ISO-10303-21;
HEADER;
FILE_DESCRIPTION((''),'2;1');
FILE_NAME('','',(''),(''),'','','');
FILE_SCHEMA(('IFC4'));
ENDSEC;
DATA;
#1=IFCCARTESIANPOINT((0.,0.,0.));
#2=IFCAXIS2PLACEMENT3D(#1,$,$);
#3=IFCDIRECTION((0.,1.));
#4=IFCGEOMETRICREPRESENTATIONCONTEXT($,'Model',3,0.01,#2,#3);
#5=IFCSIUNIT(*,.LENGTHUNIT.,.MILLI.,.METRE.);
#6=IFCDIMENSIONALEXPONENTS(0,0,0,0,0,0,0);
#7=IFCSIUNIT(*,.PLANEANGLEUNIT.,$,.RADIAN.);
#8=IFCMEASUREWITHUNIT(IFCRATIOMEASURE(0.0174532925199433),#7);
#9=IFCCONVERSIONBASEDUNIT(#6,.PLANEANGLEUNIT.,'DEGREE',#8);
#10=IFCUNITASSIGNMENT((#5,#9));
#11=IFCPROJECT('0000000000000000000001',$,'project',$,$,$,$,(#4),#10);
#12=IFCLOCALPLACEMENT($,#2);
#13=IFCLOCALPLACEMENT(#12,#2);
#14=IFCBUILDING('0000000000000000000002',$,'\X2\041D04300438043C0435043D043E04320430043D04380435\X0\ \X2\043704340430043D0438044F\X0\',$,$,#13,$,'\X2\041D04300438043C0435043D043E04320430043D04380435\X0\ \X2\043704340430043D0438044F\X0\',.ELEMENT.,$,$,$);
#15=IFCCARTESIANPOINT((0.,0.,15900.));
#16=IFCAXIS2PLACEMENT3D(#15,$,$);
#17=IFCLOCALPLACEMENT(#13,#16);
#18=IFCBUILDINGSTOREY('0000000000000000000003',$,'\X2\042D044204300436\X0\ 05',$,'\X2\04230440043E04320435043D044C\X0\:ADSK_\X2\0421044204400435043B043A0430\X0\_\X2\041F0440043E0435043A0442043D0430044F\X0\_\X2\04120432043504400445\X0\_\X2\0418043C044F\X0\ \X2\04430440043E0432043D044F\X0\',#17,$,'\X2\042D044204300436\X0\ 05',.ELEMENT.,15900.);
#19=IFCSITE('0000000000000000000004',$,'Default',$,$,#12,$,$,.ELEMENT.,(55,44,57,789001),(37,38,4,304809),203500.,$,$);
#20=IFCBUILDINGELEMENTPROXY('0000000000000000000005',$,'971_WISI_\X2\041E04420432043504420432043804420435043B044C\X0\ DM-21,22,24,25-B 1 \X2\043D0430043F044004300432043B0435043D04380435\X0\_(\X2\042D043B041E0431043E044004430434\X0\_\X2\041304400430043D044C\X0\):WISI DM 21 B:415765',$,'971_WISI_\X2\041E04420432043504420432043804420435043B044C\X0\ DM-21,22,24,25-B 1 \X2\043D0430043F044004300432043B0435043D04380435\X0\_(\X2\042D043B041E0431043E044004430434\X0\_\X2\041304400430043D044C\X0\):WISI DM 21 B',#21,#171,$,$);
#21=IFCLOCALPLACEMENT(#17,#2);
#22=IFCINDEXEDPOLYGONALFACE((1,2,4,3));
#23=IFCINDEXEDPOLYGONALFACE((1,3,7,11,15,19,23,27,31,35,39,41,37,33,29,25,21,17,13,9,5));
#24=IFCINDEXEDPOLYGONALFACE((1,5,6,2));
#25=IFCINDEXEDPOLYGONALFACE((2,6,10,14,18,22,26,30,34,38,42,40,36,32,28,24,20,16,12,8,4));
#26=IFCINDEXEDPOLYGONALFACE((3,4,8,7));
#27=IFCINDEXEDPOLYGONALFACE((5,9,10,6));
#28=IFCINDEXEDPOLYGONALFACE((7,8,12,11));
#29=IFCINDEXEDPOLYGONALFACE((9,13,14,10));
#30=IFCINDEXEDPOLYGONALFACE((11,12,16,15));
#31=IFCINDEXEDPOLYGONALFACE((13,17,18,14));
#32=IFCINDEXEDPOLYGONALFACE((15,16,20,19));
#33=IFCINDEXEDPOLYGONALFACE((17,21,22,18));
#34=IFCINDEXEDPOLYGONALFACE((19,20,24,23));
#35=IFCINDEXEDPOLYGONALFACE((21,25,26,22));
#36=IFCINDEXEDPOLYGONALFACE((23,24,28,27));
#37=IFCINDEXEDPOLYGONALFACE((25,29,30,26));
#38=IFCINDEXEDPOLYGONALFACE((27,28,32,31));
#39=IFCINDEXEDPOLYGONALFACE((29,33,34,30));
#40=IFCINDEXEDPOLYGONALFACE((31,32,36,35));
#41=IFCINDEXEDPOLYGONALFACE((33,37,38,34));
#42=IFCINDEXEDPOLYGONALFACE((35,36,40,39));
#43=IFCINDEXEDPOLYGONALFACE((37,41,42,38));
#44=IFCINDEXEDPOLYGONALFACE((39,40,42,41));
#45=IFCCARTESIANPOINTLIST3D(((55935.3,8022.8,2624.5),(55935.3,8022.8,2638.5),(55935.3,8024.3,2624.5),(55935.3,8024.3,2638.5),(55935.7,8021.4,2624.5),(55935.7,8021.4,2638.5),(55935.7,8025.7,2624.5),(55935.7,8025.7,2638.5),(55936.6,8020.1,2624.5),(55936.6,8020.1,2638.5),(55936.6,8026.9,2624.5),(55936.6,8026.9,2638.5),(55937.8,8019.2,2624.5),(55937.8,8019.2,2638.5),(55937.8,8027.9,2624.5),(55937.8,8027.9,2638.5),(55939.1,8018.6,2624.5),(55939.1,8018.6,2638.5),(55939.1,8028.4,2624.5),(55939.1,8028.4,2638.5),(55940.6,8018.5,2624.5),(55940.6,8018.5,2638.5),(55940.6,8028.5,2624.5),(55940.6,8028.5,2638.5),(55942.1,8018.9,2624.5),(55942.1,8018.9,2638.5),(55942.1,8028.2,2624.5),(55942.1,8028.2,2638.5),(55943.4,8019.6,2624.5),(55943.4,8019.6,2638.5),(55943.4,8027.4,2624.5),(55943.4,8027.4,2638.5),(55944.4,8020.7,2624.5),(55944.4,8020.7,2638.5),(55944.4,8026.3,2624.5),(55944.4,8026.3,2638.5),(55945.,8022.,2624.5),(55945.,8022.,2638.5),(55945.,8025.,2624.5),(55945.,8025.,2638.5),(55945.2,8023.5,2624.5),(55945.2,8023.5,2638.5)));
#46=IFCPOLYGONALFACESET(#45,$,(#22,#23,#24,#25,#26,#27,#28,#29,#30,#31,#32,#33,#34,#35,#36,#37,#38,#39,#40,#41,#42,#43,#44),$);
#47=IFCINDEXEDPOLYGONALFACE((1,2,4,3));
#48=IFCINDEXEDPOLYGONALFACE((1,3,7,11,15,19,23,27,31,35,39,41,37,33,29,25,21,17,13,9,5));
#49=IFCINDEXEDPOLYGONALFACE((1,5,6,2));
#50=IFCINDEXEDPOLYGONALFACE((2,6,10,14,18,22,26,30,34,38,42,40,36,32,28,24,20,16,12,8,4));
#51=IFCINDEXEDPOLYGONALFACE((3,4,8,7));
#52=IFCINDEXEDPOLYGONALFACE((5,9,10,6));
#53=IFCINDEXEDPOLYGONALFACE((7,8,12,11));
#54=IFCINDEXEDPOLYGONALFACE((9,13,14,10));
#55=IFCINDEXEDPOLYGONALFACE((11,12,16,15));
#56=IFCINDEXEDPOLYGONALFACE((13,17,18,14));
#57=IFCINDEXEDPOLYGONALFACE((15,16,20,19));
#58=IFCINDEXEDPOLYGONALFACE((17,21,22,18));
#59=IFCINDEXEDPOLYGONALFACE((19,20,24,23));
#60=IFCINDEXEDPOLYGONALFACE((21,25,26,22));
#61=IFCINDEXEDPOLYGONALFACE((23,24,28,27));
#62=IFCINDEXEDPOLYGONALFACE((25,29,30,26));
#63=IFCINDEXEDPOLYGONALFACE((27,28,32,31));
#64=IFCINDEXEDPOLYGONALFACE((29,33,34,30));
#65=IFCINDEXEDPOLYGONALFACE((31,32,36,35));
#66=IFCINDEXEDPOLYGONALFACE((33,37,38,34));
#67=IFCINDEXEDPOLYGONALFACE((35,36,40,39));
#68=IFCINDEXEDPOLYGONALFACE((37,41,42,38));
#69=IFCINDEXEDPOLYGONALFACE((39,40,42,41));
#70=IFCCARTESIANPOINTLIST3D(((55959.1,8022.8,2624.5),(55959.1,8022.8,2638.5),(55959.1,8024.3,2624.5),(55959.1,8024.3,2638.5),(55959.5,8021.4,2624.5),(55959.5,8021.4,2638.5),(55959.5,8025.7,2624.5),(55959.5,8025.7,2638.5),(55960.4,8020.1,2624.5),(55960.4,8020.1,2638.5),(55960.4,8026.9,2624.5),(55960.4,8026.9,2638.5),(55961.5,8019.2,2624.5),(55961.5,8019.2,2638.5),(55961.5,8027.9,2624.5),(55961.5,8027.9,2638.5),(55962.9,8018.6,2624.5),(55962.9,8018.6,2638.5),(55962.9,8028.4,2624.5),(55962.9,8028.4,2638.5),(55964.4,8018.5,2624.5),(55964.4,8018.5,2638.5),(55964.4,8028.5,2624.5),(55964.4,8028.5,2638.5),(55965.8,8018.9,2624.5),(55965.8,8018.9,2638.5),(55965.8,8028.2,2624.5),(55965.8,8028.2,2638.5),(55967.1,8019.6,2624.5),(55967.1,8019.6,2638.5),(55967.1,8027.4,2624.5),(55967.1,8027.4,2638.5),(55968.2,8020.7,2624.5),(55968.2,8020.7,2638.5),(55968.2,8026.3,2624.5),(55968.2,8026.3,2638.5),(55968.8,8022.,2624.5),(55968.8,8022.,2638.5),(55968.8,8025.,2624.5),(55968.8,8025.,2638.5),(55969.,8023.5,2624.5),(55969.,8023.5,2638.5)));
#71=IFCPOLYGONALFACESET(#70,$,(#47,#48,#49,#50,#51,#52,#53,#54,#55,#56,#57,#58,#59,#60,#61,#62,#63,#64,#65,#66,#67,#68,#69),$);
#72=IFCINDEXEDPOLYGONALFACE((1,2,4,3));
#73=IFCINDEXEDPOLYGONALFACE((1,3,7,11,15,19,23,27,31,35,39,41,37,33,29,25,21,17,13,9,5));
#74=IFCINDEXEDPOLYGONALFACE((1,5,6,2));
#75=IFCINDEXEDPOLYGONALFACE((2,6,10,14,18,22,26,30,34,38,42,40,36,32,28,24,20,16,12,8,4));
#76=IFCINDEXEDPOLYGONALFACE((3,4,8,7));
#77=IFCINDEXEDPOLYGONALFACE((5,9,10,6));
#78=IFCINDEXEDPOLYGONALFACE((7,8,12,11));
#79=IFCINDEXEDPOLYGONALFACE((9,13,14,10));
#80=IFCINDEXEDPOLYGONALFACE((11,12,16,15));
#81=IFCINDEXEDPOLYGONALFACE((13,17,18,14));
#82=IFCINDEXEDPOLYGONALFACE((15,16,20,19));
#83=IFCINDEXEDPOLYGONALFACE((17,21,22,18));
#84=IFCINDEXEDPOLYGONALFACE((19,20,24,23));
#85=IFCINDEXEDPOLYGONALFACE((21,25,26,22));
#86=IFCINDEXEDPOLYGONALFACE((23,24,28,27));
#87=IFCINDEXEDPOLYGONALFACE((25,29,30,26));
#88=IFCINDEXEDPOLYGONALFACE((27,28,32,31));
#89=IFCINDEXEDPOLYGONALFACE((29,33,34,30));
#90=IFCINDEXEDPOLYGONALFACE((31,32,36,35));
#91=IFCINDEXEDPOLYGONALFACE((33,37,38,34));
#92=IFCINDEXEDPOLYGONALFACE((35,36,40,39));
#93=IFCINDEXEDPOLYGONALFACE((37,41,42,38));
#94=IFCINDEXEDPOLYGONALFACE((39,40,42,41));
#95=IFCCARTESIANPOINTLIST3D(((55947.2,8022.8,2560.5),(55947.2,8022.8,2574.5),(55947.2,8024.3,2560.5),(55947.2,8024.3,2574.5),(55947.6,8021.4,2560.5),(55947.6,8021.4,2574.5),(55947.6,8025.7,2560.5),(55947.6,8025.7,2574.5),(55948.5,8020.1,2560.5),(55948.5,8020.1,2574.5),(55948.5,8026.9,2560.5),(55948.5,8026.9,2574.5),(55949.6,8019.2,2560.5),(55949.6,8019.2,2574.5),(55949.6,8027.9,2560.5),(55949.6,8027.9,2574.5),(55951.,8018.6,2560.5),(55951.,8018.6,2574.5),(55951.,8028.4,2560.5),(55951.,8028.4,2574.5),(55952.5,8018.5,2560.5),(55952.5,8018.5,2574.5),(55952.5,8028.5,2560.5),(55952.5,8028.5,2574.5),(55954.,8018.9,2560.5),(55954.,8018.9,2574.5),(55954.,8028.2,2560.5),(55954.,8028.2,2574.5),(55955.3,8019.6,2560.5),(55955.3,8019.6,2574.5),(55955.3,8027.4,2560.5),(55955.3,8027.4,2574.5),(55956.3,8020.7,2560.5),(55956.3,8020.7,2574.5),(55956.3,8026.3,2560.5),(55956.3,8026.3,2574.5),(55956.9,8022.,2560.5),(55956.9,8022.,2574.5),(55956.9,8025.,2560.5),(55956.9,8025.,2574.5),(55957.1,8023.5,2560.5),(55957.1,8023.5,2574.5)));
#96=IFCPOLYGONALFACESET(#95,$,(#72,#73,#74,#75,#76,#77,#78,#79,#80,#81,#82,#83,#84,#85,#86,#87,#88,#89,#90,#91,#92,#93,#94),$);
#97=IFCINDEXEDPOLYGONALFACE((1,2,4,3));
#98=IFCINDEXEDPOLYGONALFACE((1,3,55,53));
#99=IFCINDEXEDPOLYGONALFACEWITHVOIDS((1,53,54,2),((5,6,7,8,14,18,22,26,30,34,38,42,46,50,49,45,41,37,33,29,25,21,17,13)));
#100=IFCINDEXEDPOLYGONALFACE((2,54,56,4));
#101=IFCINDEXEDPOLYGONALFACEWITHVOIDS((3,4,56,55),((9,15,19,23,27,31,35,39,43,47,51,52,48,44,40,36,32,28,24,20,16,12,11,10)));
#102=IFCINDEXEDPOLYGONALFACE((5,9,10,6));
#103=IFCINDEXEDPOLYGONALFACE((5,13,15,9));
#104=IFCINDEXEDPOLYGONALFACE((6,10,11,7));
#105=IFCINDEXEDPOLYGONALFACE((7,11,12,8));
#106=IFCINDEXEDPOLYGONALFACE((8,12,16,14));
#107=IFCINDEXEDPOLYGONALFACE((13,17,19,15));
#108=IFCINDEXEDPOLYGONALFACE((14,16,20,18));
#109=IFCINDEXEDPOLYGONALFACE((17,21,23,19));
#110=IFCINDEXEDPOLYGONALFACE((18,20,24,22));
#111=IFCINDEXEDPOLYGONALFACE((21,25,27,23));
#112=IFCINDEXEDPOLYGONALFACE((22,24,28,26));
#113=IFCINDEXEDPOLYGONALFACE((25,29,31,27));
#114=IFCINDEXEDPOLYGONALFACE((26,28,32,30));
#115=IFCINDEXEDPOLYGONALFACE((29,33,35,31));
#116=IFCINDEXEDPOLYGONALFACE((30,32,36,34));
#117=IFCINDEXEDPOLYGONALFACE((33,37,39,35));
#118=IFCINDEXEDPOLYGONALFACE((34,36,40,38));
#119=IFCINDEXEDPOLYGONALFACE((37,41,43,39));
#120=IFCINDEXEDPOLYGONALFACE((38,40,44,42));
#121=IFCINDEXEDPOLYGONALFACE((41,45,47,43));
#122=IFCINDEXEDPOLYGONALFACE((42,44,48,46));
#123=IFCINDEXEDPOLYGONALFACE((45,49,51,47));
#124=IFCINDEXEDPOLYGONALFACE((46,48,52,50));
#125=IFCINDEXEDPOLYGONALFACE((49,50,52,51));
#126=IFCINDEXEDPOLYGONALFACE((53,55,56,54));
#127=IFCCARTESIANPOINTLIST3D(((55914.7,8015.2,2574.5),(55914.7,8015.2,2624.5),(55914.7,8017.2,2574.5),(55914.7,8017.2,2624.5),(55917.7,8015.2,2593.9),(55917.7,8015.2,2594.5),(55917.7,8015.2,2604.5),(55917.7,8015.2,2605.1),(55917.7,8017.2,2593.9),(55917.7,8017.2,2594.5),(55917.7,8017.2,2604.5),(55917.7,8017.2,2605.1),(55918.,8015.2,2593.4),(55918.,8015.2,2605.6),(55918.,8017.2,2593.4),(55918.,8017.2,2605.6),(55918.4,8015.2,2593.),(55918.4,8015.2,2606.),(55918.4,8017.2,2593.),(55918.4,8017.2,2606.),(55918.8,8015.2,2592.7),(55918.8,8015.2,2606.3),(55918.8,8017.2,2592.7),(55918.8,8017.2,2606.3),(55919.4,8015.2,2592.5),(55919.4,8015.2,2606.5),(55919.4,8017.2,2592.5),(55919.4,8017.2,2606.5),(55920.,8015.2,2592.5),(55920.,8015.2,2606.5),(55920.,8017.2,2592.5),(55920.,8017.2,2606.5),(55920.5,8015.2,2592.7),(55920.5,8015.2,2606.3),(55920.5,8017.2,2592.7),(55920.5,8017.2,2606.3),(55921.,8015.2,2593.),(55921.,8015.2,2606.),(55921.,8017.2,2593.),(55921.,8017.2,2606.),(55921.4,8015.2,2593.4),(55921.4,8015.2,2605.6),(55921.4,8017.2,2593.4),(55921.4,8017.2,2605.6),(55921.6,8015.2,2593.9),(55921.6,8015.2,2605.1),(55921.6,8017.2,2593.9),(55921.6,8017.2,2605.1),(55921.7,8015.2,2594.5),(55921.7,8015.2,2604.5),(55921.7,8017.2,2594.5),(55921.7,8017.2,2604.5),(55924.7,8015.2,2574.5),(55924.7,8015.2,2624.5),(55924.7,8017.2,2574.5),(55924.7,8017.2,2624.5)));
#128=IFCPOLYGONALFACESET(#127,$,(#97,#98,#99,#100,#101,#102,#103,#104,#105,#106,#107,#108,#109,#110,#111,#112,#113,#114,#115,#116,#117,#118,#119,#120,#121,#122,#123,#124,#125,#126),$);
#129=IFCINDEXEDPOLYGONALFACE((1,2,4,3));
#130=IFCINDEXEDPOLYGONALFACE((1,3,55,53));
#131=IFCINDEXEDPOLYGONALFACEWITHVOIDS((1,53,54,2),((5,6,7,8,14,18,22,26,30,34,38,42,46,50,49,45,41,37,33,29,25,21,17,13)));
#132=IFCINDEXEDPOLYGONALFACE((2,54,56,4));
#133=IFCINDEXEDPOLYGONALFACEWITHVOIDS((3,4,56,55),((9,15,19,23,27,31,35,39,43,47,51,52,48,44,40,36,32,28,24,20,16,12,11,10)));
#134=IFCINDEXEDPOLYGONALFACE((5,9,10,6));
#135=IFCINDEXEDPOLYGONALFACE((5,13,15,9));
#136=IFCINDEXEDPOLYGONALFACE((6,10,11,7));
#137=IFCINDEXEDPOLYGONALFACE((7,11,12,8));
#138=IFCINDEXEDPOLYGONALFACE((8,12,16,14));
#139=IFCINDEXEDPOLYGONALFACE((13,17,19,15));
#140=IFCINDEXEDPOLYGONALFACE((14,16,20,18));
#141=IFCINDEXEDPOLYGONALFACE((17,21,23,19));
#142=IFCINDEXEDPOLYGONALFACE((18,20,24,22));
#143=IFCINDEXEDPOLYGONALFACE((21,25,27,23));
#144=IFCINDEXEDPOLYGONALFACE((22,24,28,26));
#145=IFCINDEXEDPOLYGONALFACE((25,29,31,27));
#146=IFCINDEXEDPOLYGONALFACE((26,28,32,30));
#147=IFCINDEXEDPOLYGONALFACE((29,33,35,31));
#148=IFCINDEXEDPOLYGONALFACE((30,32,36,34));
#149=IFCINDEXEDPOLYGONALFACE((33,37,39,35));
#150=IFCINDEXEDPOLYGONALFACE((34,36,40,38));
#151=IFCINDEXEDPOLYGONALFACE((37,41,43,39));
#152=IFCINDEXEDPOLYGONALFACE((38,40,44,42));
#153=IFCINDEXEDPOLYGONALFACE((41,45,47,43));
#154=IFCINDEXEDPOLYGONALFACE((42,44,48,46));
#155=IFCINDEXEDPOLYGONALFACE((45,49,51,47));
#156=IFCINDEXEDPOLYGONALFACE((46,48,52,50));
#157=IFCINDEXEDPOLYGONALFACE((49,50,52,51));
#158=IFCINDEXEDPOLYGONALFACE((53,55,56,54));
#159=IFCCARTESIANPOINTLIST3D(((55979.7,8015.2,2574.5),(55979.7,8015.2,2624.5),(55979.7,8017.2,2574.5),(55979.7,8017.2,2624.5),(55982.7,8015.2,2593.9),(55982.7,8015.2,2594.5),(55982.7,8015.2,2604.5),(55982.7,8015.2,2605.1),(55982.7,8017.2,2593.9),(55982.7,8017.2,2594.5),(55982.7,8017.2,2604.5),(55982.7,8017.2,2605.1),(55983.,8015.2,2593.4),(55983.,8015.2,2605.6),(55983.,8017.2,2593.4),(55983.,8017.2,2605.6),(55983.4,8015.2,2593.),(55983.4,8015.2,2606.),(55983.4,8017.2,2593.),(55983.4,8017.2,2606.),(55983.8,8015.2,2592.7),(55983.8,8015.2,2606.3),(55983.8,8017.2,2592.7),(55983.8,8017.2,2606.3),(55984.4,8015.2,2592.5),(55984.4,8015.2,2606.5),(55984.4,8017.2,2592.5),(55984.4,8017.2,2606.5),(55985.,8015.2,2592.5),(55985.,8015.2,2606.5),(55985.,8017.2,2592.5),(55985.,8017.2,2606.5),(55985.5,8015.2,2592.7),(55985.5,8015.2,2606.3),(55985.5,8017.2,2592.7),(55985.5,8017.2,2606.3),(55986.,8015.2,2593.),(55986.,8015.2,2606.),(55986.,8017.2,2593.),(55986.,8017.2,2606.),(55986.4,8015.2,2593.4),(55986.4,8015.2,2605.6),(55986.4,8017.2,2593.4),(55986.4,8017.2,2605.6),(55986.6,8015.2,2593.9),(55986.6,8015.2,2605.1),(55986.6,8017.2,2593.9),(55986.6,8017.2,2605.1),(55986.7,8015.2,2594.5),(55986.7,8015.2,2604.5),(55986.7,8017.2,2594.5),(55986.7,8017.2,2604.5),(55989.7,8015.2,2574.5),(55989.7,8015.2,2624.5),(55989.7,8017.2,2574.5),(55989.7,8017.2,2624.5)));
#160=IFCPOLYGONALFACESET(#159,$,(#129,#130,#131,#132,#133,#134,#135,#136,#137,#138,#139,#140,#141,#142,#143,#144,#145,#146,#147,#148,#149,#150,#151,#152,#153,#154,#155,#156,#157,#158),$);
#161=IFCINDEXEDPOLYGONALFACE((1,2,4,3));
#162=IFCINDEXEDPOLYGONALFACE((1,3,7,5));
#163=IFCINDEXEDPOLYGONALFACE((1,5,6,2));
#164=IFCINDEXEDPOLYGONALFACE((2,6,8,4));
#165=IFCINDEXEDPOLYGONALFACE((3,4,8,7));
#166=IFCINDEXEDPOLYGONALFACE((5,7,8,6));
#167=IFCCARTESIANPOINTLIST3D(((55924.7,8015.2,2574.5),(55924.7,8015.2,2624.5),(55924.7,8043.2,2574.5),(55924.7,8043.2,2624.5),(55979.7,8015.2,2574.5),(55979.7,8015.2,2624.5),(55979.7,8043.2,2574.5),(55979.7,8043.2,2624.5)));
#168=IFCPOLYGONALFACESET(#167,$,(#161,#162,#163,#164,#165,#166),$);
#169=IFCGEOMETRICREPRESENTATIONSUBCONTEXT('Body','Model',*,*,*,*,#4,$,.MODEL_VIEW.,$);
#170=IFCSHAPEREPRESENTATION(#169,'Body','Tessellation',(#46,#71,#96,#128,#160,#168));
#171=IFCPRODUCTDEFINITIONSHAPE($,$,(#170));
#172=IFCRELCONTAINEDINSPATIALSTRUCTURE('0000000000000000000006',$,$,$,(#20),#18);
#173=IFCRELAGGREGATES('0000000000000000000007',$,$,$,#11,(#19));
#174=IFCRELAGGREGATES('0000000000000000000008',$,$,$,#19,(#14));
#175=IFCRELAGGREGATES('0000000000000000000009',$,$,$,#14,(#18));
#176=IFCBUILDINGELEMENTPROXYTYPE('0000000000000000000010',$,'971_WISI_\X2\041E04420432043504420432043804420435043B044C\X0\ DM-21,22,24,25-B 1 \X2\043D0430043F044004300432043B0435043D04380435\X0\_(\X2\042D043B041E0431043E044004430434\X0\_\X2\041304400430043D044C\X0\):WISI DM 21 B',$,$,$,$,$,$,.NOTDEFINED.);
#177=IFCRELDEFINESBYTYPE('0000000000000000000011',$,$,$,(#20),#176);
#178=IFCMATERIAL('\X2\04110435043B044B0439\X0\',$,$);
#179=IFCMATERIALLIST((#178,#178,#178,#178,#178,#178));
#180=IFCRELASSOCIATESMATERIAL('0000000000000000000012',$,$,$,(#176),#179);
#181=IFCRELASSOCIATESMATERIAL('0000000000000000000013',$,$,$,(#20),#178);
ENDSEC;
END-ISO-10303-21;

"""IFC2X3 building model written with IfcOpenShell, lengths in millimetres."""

from ifc_helpers import new_model, entity, si_unit, converted_unit, direction, frame, origin, origin_2d_with_axis, place, context, subcontext, project, spatial, rectangle, circle, extrude, source, transform, mapped, material, material_list, type_object, type_shapes, element, save


model = new_model("IFC2X3")

# Units and contexts
model_context = context("Model", 3, precision=0.01, world=origin(), true_north=direction((0.0, 1.0)))
body_context = subcontext(model_context, "Body", "Model", "MODEL_VIEW")
ifc_project = project(units=[si_unit("LENGTHUNIT", "METRE", prefix="MILLI"), converted_unit("PLANEANGLEUNIT", "DEGREE", entity("IfcRatioMeasure", 0.0174532925199433), si_unit("PLANEANGLEUNIT", "RADIAN"), dimensions=[0, 0, 0, 0, 0, 0, 0])], contexts=[model_context])

# Site, building, storey
site_placement = place(None, origin())
site = spatial("IfcSite", under=ifc_project, at=site_placement, Name="Default", CompositionType="ELEMENT", RefLatitude=(55, 44, 57, 789001), RefLongitude=(37, 38, 4, 304809), RefElevation=203500.0)
building_placement = place(site_placement, origin())
building = spatial("IfcBuilding", under=site, at=building_placement, Name="Наименование здания", LongName="Наименование здания", CompositionType="ELEMENT")
storey_placement = place(building_placement, frame((0.0, 0.0, 15900.0)))
storey = spatial("IfcBuildingStorey", under=building, at=storey_placement, Name="Этаж 05", ObjectType="Уровень:ADSK_Стрелка_Проектная_Вверх_Имя уровня", LongName="Этаж 05", CompositionType="ELEMENT", Elevation=15900.0)

# Building element proxy
ifc_material = material(Name="Белый")
ifc_material_list = material_list([ifc_material, ifc_material, ifc_material, ifc_material, ifc_material, ifc_material])
building_element_proxy_type = type_object("IfcBuildingElementProxyType", Name="971_WISI_Ответвитель DM-21,22,24,25-B 1 направление_(ЭлОборуд_Грань):WISI DM 21 B", PredefinedType="NOTDEFINED", material=ifc_material_list)
cartesian_point = entity("IfcCartesianPoint", [-5.0, -25.0])
shared_polyline = entity("IfcPolyline", [cartesian_point, entity("IfcCartesianPoint", [5.0, -25.0]), entity("IfcCartesianPoint", [5.0, 25.0]), entity("IfcCartesianPoint", [-5.0, 25.0]), cartesian_point])
ifc_direction_1 = entity("IfcDirection", [-1.0, 0.0])
ifc_direction_2 = entity("IfcDirection", [0.0, 0.0, 1.0])
ifc_direction_3 = entity("IfcDirection", [-1.0, 0.0])
ifc_direction_4 = entity("IfcDirection", [0.0, 0.0, 1.0])
shared_shape = source(origin(), body_context, "Body", "SweptSolid", [
    extrude(circle(Radius=5.0, at=origin_2d_with_axis()), frame((11.9, 25.0, 8.4), z_axis=(0.0, 1.0, 0.0), x_axis=(-1.0, 0.0, 0.0)), (0.0, 0.0, 1.0), 14.0),
    extrude(circle(Radius=5.0, at=origin_2d_with_axis()), frame((-11.8, 25.0, 8.4), z_axis=(0.0, 1.0, 0.0), x_axis=(-1.0, 0.0, 0.0)), (0.0, 0.0, 1.0), 14.0),
    extrude(circle(Radius=5.0, at=origin_2d_with_axis()), frame((0.0, -39.0, 8.4), z_axis=(0.0, 1.0, 0.0), x_axis=(-1.0, 0.0, 0.0)), (0.0, 0.0, 1.0), 14.0),
    entity("IfcExtrudedAreaSolid", entity("IfcArbitraryProfileDefWithVoids", "AREA", None, shared_polyline, [entity("IfcCompositeCurve", [entity("IfcCompositeCurveSegment", "CONTINUOUS", True, entity("IfcPolyline", [entity("IfcCartesianPoint", [2.0, 5.0]), entity("IfcCartesianPoint", [2.0, -5.0])])), entity("IfcCompositeCurveSegment", "CONTINUOUS", False, entity("IfcTrimmedCurve", entity("IfcCircle", entity("IfcAxis2Placement2D", entity("IfcCartesianPoint", [0.0, -5.0]), ifc_direction_1), 2.0), [entity("IfcParameterValue", 0.0)], [entity("IfcParameterValue", 180.0)], True, "PARAMETER")), entity("IfcCompositeCurveSegment", "CONTINUOUS", True, entity("IfcPolyline", [entity("IfcCartesianPoint", [-2.0, -5.0]), entity("IfcCartesianPoint", [-2.0, 5.0])])), entity("IfcCompositeCurveSegment", "CONTINUOUS", False, entity("IfcTrimmedCurve", entity("IfcCircle", entity("IfcAxis2Placement2D", entity("IfcCartesianPoint", [0.0, 5.0]), ifc_direction_1), 2.0), [entity("IfcParameterValue", 180.0)], [entity("IfcParameterValue", 0.0)], True, "PARAMETER"))], False)]), entity("IfcAxis2Placement3D", entity("IfcCartesianPoint", [32.5, 0.0, 0.0]), ifc_direction_2, entity("IfcDirection", [-1.0, 0.0, 0.0])), ifc_direction_2, 2.0),
    entity("IfcExtrudedAreaSolid", entity("IfcArbitraryProfileDefWithVoids", "AREA", None, shared_polyline, [entity("IfcCompositeCurve", [entity("IfcCompositeCurveSegment", "CONTINUOUS", True, entity("IfcPolyline", [entity("IfcCartesianPoint", [-2.0, -5.0]), entity("IfcCartesianPoint", [-2.0, 5.0])])), entity("IfcCompositeCurveSegment", "CONTINUOUS", False, entity("IfcTrimmedCurve", entity("IfcCircle", entity("IfcAxis2Placement2D", entity("IfcCartesianPoint", [0.0, 5.0]), ifc_direction_3), 2.0), [entity("IfcParameterValue", 180.0)], [entity("IfcParameterValue", 0.0)], True, "PARAMETER")), entity("IfcCompositeCurveSegment", "CONTINUOUS", True, entity("IfcPolyline", [entity("IfcCartesianPoint", [2.0, 5.0]), entity("IfcCartesianPoint", [2.0, -5.0])])), entity("IfcCompositeCurveSegment", "CONTINUOUS", False, entity("IfcTrimmedCurve", entity("IfcCircle", entity("IfcAxis2Placement2D", entity("IfcCartesianPoint", [0.0, -5.0]), ifc_direction_3), 2.0), [entity("IfcParameterValue", 0.0)], [entity("IfcParameterValue", 180.0)], True, "PARAMETER"))], False)]), entity("IfcAxis2Placement3D", entity("IfcCartesianPoint", [-32.5, 0.0, 0.0]), ifc_direction_4, entity("IfcDirection", [-1.0, 0.0, 0.0])), ifc_direction_4, 2.0),
    extrude(rectangle(XDim=55.0, YDim=50.0, at=origin_2d_with_axis()), frame((0.0, 0.0, 0.0), z_axis=(0.0, 0.0, 1.0), x_axis=(-1.0, 0.0, 0.0)), (0.0, 0.0, 1.0), 28.0),
])
type_shapes(building_element_proxy_type, [shared_shape])
for number, where, z_axis, x_axis, name in (
    (1, (55952.2, 8015.1, 2599.5), (0.0, 1.0, 0.0), (-1.0, 0.0, 0.0), "971_WISI_Ответвитель DM-21,22,24,25-B 1 направление_(ЭлОборуд_Грань):WISI DM 21 B:415765"),
):
    element("IfcBuildingElementProxy", number, at=place(storey_placement, frame(where, z_axis=z_axis, x_axis=x_axis)), inside=storey, type_object=building_element_proxy_type, material=ifc_material, Name=name, ObjectType="971_WISI_Ответвитель DM-21,22,24,25-B 1 направление_(ЭлОборуд_Грань):WISI DM 21 B", context=body_context, shape_type="MappedRepresentation", body=[
        mapped(shared_shape, transform((0.0, 0.0, 0.0), scale=1.0)),
    ])

save(model, "model.ifc")
